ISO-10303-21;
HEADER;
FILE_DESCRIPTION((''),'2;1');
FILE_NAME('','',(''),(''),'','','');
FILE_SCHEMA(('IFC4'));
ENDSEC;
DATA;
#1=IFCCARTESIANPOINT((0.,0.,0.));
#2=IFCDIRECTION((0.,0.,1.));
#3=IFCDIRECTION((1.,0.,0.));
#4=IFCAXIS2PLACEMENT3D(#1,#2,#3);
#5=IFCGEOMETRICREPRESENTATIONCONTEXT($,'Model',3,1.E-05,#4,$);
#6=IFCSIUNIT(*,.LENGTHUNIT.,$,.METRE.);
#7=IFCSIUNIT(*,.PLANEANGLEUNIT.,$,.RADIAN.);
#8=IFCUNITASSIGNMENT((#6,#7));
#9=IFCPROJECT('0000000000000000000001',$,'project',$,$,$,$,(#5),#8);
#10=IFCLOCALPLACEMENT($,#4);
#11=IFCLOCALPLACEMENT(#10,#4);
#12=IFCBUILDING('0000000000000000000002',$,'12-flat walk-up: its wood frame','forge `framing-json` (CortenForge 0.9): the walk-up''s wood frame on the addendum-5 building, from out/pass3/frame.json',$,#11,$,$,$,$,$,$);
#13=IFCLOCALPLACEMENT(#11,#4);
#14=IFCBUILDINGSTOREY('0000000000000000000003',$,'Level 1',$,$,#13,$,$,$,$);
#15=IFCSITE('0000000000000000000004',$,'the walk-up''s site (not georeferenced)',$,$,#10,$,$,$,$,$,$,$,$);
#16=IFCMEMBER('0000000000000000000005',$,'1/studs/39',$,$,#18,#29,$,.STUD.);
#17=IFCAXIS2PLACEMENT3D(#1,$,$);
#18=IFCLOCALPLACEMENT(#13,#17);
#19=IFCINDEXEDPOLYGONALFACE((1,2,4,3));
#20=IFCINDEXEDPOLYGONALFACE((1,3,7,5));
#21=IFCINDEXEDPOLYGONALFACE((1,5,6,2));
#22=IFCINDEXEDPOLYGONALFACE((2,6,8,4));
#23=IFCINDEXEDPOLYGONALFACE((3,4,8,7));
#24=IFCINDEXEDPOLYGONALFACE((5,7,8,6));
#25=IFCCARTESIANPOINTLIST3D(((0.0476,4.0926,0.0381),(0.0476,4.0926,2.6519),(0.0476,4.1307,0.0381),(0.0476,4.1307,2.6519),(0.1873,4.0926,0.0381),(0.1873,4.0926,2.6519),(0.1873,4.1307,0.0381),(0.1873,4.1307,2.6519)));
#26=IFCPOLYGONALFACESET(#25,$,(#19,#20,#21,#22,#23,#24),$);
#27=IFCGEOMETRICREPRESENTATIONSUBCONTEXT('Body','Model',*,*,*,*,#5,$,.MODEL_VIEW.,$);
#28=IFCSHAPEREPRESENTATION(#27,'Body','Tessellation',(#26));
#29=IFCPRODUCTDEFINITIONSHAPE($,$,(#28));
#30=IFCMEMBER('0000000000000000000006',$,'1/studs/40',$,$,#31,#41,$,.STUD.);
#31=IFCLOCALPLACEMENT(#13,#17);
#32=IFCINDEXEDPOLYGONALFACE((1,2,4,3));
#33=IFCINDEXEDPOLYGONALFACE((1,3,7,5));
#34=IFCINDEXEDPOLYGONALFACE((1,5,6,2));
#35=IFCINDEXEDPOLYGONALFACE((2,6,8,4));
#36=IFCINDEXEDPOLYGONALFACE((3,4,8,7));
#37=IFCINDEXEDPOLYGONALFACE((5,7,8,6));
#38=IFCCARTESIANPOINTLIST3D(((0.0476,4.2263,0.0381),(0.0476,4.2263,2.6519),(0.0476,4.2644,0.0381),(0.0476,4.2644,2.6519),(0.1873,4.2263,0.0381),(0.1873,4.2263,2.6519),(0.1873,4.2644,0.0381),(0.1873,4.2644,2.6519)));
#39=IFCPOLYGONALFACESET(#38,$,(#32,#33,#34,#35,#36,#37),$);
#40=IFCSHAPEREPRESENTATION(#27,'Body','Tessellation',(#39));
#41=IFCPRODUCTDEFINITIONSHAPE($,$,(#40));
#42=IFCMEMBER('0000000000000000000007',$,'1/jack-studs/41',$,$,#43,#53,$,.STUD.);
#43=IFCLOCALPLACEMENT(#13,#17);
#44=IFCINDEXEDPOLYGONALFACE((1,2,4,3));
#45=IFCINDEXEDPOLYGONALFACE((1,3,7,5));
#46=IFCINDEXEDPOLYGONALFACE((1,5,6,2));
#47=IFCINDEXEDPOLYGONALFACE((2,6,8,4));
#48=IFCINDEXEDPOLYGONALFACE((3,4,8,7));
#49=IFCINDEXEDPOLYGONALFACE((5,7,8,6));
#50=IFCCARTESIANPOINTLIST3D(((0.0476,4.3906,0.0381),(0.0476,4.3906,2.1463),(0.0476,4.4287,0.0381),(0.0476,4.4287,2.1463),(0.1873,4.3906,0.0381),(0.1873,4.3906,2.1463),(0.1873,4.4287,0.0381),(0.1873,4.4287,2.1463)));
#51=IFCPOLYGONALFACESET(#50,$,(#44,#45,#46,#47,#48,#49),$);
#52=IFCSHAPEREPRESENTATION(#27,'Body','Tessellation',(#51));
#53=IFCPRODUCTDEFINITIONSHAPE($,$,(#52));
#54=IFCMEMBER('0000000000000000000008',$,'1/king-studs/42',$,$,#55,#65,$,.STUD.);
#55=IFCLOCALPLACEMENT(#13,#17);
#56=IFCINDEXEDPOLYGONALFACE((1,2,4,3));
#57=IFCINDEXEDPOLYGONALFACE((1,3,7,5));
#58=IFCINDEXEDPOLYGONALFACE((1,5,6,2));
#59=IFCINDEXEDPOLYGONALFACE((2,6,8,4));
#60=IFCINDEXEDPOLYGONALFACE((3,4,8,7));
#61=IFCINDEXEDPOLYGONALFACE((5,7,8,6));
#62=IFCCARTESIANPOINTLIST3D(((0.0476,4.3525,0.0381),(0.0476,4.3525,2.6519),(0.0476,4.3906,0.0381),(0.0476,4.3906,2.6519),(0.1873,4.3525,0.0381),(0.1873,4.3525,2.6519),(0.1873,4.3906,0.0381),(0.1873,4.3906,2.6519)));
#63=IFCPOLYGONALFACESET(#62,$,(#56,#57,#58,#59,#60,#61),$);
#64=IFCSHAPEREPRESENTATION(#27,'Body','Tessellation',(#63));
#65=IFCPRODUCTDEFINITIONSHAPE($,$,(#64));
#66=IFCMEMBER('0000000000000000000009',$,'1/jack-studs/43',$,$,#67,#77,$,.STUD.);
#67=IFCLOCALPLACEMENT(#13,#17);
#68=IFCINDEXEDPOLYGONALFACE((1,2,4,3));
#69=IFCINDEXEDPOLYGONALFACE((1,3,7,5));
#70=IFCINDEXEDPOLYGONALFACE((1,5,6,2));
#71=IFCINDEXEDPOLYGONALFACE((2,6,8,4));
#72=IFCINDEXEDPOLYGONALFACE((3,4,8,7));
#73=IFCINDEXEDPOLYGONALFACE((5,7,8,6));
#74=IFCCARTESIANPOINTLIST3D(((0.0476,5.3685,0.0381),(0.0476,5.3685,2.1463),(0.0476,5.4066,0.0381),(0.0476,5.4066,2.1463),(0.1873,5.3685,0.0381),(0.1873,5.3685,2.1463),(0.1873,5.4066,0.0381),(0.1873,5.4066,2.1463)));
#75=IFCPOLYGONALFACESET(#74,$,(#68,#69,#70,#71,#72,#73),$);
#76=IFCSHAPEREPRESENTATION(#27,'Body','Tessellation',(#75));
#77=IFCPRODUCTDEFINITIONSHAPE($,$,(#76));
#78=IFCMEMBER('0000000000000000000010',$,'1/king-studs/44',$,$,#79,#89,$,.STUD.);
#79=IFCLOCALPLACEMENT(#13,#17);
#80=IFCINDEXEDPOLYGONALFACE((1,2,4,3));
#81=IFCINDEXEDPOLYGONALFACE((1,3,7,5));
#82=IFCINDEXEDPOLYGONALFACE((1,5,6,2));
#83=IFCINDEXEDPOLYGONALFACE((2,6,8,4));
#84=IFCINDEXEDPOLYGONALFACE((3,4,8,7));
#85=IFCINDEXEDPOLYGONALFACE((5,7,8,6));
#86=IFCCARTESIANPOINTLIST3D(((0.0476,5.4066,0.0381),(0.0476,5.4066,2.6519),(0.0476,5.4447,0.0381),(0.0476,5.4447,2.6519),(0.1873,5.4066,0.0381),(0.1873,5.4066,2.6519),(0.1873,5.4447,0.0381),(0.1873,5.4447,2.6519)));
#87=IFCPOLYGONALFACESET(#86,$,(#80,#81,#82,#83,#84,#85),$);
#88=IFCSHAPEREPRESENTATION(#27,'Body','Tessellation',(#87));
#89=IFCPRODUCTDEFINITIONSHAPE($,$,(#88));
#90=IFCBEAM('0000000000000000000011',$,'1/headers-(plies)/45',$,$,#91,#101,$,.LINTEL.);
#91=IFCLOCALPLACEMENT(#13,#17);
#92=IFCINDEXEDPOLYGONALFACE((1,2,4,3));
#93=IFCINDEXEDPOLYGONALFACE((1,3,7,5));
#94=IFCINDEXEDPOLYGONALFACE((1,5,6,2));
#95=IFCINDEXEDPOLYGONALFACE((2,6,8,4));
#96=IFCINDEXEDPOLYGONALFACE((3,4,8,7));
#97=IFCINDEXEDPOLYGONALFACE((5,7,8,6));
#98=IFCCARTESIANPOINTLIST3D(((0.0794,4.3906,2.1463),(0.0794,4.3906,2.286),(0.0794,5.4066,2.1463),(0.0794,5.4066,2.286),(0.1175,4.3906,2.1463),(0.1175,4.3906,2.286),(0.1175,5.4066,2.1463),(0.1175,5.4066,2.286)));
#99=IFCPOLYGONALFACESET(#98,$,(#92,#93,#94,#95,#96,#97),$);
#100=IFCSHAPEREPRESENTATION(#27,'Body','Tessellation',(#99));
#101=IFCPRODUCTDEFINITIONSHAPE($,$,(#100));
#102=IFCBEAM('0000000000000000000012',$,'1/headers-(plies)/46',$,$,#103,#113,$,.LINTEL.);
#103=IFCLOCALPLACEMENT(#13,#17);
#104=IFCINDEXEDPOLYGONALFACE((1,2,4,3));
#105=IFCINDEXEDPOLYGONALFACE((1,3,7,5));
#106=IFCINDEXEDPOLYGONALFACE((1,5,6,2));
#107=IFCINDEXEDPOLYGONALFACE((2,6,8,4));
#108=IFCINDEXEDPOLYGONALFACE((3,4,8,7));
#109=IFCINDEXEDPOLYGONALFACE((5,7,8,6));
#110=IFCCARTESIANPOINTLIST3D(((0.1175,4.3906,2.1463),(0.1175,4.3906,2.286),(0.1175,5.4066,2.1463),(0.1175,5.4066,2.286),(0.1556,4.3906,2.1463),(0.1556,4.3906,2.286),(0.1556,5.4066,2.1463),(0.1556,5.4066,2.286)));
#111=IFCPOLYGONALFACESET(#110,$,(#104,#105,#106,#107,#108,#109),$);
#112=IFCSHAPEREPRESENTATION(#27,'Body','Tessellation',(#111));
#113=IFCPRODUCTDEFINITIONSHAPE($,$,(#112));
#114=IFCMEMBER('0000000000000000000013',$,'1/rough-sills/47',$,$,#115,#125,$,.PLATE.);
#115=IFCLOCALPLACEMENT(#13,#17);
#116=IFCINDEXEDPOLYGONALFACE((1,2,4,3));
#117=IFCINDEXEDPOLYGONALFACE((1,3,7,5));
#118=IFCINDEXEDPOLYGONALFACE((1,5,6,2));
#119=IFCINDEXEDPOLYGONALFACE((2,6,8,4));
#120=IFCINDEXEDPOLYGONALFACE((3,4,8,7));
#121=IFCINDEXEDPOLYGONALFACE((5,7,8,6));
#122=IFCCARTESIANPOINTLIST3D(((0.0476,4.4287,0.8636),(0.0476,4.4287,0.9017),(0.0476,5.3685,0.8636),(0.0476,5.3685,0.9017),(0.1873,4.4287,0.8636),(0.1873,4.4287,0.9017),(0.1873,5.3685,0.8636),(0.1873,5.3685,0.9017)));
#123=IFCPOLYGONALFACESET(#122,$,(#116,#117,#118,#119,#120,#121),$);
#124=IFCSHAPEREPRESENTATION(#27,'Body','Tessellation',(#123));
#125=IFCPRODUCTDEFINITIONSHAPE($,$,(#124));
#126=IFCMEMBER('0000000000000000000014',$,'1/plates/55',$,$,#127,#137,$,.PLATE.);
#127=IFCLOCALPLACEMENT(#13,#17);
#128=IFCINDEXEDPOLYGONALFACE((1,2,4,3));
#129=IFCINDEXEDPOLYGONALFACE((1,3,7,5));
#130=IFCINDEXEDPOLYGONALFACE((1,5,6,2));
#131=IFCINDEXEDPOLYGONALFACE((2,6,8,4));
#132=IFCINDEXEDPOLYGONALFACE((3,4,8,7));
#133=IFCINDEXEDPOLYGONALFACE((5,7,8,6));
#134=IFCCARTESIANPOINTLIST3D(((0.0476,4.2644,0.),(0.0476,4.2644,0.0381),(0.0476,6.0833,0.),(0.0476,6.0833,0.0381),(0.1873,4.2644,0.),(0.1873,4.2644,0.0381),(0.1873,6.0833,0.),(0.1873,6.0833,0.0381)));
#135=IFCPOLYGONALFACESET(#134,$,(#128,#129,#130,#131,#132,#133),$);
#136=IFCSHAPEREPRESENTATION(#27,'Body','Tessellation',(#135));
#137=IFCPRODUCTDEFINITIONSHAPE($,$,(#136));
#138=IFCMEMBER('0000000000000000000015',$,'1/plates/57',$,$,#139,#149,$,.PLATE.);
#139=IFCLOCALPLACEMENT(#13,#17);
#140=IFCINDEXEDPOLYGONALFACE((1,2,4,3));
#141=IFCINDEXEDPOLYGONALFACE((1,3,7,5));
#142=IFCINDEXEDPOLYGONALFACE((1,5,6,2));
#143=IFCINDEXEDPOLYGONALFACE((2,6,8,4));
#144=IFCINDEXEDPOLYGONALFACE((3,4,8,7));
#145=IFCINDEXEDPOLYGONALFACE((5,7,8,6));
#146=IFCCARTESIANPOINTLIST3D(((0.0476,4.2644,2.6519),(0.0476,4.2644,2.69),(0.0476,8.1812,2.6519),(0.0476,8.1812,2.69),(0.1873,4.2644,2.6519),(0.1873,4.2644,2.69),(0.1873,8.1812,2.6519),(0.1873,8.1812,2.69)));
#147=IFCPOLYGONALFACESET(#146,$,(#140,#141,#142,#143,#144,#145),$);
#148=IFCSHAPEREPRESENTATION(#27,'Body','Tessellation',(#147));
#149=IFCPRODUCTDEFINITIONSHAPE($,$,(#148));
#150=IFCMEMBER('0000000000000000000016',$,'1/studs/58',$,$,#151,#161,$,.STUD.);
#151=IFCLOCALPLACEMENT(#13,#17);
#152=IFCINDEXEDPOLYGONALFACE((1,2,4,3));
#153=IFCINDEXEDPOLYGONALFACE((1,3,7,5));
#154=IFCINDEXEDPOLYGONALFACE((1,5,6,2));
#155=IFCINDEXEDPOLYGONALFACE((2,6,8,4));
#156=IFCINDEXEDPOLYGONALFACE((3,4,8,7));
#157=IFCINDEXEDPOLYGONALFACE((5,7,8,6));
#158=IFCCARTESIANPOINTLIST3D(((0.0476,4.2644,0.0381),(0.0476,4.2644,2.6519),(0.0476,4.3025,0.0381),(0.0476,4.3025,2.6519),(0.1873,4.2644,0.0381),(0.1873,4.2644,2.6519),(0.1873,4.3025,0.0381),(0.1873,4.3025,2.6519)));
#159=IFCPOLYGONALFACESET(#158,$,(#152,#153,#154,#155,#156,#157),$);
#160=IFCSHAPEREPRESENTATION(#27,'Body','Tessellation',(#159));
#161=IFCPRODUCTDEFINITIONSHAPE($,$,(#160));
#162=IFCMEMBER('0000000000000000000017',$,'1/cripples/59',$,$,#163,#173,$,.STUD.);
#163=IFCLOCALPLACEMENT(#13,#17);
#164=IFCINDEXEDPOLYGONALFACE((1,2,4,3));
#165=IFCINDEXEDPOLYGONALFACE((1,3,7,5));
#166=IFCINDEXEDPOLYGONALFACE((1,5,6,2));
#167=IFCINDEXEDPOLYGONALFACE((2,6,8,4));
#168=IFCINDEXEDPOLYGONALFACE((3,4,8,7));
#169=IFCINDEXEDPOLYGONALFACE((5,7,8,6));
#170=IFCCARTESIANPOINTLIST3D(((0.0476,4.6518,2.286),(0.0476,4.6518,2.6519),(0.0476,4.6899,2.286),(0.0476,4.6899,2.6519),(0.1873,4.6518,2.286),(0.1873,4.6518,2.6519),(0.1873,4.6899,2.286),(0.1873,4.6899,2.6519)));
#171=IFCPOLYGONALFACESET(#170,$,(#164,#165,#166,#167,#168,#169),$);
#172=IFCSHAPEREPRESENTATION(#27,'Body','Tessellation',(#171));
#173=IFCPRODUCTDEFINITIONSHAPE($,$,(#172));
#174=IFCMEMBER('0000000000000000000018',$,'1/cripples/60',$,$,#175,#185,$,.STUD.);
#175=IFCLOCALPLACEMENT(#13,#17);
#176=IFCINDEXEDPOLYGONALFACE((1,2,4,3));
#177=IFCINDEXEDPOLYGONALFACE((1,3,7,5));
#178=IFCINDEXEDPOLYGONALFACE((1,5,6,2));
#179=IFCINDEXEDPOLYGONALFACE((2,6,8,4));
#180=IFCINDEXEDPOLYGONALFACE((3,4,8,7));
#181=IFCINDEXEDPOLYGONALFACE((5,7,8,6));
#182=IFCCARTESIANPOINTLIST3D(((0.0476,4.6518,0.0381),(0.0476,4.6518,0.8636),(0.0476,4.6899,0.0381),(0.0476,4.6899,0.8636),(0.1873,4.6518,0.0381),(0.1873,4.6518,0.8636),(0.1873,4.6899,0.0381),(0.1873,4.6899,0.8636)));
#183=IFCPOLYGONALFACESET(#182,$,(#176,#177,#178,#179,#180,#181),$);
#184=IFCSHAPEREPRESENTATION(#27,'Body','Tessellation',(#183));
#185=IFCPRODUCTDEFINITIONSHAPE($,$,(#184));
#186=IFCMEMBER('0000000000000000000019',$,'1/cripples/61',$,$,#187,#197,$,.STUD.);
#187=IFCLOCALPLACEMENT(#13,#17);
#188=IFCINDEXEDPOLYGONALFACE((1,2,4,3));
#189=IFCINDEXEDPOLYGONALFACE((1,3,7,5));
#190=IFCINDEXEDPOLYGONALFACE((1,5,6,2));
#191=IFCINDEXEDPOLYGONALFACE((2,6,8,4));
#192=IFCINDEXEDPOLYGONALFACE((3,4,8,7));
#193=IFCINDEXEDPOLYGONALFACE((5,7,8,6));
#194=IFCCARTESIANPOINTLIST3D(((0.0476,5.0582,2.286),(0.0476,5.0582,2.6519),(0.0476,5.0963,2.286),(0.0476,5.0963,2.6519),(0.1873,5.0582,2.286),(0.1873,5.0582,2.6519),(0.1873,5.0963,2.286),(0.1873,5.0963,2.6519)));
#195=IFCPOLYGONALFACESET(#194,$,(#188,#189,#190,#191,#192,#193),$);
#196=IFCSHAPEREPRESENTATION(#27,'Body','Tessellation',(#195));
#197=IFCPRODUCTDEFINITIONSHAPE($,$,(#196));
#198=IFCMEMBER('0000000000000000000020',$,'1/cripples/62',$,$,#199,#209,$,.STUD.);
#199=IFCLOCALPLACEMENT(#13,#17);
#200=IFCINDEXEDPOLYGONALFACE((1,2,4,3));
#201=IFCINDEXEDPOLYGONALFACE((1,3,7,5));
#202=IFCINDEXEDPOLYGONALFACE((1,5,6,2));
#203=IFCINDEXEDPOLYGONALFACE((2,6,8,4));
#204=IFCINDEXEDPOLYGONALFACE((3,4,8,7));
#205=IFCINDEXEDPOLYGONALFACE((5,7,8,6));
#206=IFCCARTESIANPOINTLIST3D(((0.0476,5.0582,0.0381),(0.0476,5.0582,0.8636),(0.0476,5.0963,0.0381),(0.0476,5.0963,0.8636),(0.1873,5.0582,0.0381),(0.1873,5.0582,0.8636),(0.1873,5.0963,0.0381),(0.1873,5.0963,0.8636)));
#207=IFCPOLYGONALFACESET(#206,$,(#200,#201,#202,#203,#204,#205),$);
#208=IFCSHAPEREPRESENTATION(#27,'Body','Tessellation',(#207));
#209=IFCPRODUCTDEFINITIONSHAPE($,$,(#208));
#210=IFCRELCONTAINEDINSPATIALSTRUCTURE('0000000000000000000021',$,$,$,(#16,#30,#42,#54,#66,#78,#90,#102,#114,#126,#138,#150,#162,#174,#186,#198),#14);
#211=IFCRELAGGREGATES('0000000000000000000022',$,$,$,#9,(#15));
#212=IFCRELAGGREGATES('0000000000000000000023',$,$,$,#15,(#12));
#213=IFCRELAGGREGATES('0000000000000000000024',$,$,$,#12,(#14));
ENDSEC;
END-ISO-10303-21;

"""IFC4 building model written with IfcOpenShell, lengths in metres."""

from ifc_helpers import new_model, si_unit, frame, frame_2d, origin, origin_with_axes, place, context, subcontext, project, spatial, rectangle, extrude, element, save


model = new_model("IFC4")

# Units and contexts
model_context = context("Model", 3, precision=1e-05, world=origin_with_axes())
body_context = subcontext(model_context, "Body", "Model", "MODEL_VIEW")
ifc_project = project(units=[si_unit("LENGTHUNIT", "METRE"), si_unit("PLANEANGLEUNIT", "RADIAN")], contexts=[model_context])

# Site, building, storey
site_placement = place(None, origin_with_axes())
site = spatial("IfcSite", under=ifc_project, at=site_placement, Name="the walk-up's site (not georeferenced)")
building_placement = place(site_placement, origin_with_axes())
building = spatial("IfcBuilding", under=site, at=building_placement, Name="12-flat walk-up: its wood frame", Description="forge `framing-json` (CortenForge 0.9): the walk-up's wood frame on the addendum-5 building, from out/pass3/frame.json")
storey_placement = place(building_placement, origin_with_axes())
storey = spatial("IfcBuildingStorey", under=building, at=storey_placement, Name="Level 1")

# Members
for number, where, z_axis, x_axis, name in (
    (1, (0.0476, 4.0926, 0.0381), (0.0, 0.0, 1.0), (1.0, 0.0, 0.0), "1/studs/39"),
    (2, (0.0476, 4.2263, 0.0381), (0.0, 0.0, 1.0), (1.0, 0.0, 0.0), "1/studs/40"),
):
    element("IfcMember", number, at=place(storey_placement, frame(where, z_axis=z_axis, x_axis=x_axis)), inside=storey, Name=name, PredefinedType="STUD", context=body_context, shape_type="SweptSolid", body=[
        extrude(rectangle(XDim=0.1397, YDim=0.0381, at=frame_2d((0.0698, 0.0191))), origin(), (0.0, 0.0, 1.0), 2.6138),
    ])
member_1_placement = place(storey_placement, frame((0.0476, 4.3906, 0.0381), z_axis=(0.0, 0.0, 1.0), x_axis=(1.0, 0.0, 0.0)))
element("IfcMember", 3, at=member_1_placement, inside=storey, Name="1/jack-studs/41", PredefinedType="STUD", context=body_context, shape_type="SweptSolid", body=[
    extrude(rectangle(XDim=0.1397, YDim=0.0381, at=frame_2d((0.0698, 0.0191))), origin(), (0.0, 0.0, 1.0), 2.1082),
])
member_2_placement = place(storey_placement, frame((0.0476, 4.3525, 0.0381), z_axis=(0.0, 0.0, 1.0), x_axis=(1.0, 0.0, 0.0)))
element("IfcMember", 4, at=member_2_placement, inside=storey, Name="1/king-studs/42", PredefinedType="STUD", context=body_context, shape_type="SweptSolid", body=[
    extrude(rectangle(XDim=0.1397, YDim=0.0381, at=frame_2d((0.0698, 0.019))), origin(), (0.0, 0.0, 1.0), 2.6138),
])
member_3_placement = place(storey_placement, frame((0.0476, 5.3685, 0.0381), z_axis=(0.0, 0.0, 1.0), x_axis=(1.0, 0.0, 0.0)))
element("IfcMember", 5, at=member_3_placement, inside=storey, Name="1/jack-studs/43", PredefinedType="STUD", context=body_context, shape_type="SweptSolid", body=[
    extrude(rectangle(XDim=0.1397, YDim=0.0381, at=frame_2d((0.0698, 0.019))), origin(), (0.0, 0.0, 1.0), 2.1082),
])
member_4_placement = place(storey_placement, frame((0.0476, 5.4066, 0.0381), z_axis=(0.0, 0.0, 1.0), x_axis=(1.0, 0.0, 0.0)))
element("IfcMember", 6, at=member_4_placement, inside=storey, Name="1/king-studs/44", PredefinedType="STUD", context=body_context, shape_type="SweptSolid", body=[
    extrude(rectangle(XDim=0.1397, YDim=0.0381, at=frame_2d((0.0698, 0.0191))), origin(), (0.0, 0.0, 1.0), 2.6138),
])

# Beams
for number, where, z_axis, x_axis, name in (
    (7, (0.0794, 4.3906, 2.1463), (0.0, 0.0, 1.0), (1.0, 0.0, 0.0), "1/headers-(plies)/45"),
    (8, (0.1175, 4.3906, 2.1463), (0.0, 0.0, 1.0), (1.0, 0.0, 0.0), "1/headers-(plies)/46"),
):
    element("IfcBeam", number, at=place(storey_placement, frame(where, z_axis=z_axis, x_axis=x_axis)), inside=storey, Name=name, PredefinedType="LINTEL", context=body_context, shape_type="SweptSolid", body=[
        extrude(rectangle(XDim=0.0381, YDim=1.016, at=frame_2d((0.019, 0.508))), origin(), (0.0, 0.0, 1.0), 0.1397),
    ])

# Members
member_5_placement = place(storey_placement, frame((0.0476, 4.4287, 0.8636), z_axis=(0.0, 0.0, 1.0), x_axis=(1.0, 0.0, 0.0)))
element("IfcMember", 9, at=member_5_placement, inside=storey, Name="1/rough-sills/47", PredefinedType="PLATE", context=body_context, shape_type="SweptSolid", body=[
    extrude(rectangle(XDim=0.1397, YDim=0.9398, at=frame_2d((0.0698, 0.4699))), origin(), (0.0, 0.0, 1.0), 0.0381),
])
member_6_placement = place(storey_placement, frame((0.0476, 4.2644, 0.0), z_axis=(0.0, 0.0, 1.0), x_axis=(1.0, 0.0, 0.0)))
element("IfcMember", 10, at=member_6_placement, inside=storey, Name="1/plates/55", PredefinedType="PLATE", context=body_context, shape_type="SweptSolid", body=[
    extrude(rectangle(XDim=0.1397, YDim=1.8189, at=frame_2d((0.0698, 0.9094))), origin(), (0.0, 0.0, 1.0), 0.0381),
])
member_7_placement = place(storey_placement, frame((0.0476, 4.2644, 2.6519), z_axis=(0.0, 0.0, 1.0), x_axis=(1.0, 0.0, 0.0)))
element("IfcMember", 11, at=member_7_placement, inside=storey, Name="1/plates/57", PredefinedType="PLATE", context=body_context, shape_type="SweptSolid", body=[
    extrude(rectangle(XDim=0.1397, YDim=3.9168, at=frame_2d((0.0698, 1.9584))), origin(), (0.0, 0.0, 1.0), 0.0381),
])
member_8_placement = place(storey_placement, frame((0.0476, 4.2644, 0.0381), z_axis=(0.0, 0.0, 1.0), x_axis=(1.0, 0.0, 0.0)))
element("IfcMember", 12, at=member_8_placement, inside=storey, Name="1/studs/58", PredefinedType="STUD", context=body_context, shape_type="SweptSolid", body=[
    extrude(rectangle(XDim=0.1397, YDim=0.0381, at=frame_2d((0.0698, 0.0191))), origin(), (0.0, 0.0, 1.0), 2.6138),
])
member_9_placement = place(storey_placement, frame((0.0476, 4.6518, 2.286), z_axis=(0.0, 0.0, 1.0), x_axis=(1.0, 0.0, 0.0)))
element("IfcMember", 13, at=member_9_placement, inside=storey, Name="1/cripples/59", PredefinedType="STUD", context=body_context, shape_type="SweptSolid", body=[
    extrude(rectangle(XDim=0.1397, YDim=0.0381, at=frame_2d((0.0698, 0.0191))), origin(), (0.0, 0.0, 1.0), 0.3659),
])
member_10_placement = place(storey_placement, frame((0.0476, 4.6518, 0.0381), z_axis=(0.0, 0.0, 1.0), x_axis=(1.0, 0.0, 0.0)))
element("IfcMember", 14, at=member_10_placement, inside=storey, Name="1/cripples/60", PredefinedType="STUD", context=body_context, shape_type="SweptSolid", body=[
    extrude(rectangle(XDim=0.1397, YDim=0.0381, at=frame_2d((0.0698, 0.0191))), origin(), (0.0, 0.0, 1.0), 0.8255),
])
member_11_placement = place(storey_placement, frame((0.0476, 5.0582, 2.286), z_axis=(0.0, 0.0, 1.0), x_axis=(1.0, 0.0, 0.0)))
element("IfcMember", 15, at=member_11_placement, inside=storey, Name="1/cripples/61", PredefinedType="STUD", context=body_context, shape_type="SweptSolid", body=[
    extrude(rectangle(XDim=0.1397, YDim=0.0381, at=frame_2d((0.0698, 0.0191))), origin(), (0.0, 0.0, 1.0), 0.3659),
])
member_12_placement = place(storey_placement, frame((0.0476, 5.0582, 0.0381), z_axis=(0.0, 0.0, 1.0), x_axis=(1.0, 0.0, 0.0)))
element("IfcMember", 16, at=member_12_placement, inside=storey, Name="1/cripples/62", PredefinedType="STUD", context=body_context, shape_type="SweptSolid", body=[
    extrude(rectangle(XDim=0.1397, YDim=0.0381, at=frame_2d((0.0698, 0.0191))), origin(), (0.0, 0.0, 1.0), 0.8255),
])

save(model, "model.ifc")
